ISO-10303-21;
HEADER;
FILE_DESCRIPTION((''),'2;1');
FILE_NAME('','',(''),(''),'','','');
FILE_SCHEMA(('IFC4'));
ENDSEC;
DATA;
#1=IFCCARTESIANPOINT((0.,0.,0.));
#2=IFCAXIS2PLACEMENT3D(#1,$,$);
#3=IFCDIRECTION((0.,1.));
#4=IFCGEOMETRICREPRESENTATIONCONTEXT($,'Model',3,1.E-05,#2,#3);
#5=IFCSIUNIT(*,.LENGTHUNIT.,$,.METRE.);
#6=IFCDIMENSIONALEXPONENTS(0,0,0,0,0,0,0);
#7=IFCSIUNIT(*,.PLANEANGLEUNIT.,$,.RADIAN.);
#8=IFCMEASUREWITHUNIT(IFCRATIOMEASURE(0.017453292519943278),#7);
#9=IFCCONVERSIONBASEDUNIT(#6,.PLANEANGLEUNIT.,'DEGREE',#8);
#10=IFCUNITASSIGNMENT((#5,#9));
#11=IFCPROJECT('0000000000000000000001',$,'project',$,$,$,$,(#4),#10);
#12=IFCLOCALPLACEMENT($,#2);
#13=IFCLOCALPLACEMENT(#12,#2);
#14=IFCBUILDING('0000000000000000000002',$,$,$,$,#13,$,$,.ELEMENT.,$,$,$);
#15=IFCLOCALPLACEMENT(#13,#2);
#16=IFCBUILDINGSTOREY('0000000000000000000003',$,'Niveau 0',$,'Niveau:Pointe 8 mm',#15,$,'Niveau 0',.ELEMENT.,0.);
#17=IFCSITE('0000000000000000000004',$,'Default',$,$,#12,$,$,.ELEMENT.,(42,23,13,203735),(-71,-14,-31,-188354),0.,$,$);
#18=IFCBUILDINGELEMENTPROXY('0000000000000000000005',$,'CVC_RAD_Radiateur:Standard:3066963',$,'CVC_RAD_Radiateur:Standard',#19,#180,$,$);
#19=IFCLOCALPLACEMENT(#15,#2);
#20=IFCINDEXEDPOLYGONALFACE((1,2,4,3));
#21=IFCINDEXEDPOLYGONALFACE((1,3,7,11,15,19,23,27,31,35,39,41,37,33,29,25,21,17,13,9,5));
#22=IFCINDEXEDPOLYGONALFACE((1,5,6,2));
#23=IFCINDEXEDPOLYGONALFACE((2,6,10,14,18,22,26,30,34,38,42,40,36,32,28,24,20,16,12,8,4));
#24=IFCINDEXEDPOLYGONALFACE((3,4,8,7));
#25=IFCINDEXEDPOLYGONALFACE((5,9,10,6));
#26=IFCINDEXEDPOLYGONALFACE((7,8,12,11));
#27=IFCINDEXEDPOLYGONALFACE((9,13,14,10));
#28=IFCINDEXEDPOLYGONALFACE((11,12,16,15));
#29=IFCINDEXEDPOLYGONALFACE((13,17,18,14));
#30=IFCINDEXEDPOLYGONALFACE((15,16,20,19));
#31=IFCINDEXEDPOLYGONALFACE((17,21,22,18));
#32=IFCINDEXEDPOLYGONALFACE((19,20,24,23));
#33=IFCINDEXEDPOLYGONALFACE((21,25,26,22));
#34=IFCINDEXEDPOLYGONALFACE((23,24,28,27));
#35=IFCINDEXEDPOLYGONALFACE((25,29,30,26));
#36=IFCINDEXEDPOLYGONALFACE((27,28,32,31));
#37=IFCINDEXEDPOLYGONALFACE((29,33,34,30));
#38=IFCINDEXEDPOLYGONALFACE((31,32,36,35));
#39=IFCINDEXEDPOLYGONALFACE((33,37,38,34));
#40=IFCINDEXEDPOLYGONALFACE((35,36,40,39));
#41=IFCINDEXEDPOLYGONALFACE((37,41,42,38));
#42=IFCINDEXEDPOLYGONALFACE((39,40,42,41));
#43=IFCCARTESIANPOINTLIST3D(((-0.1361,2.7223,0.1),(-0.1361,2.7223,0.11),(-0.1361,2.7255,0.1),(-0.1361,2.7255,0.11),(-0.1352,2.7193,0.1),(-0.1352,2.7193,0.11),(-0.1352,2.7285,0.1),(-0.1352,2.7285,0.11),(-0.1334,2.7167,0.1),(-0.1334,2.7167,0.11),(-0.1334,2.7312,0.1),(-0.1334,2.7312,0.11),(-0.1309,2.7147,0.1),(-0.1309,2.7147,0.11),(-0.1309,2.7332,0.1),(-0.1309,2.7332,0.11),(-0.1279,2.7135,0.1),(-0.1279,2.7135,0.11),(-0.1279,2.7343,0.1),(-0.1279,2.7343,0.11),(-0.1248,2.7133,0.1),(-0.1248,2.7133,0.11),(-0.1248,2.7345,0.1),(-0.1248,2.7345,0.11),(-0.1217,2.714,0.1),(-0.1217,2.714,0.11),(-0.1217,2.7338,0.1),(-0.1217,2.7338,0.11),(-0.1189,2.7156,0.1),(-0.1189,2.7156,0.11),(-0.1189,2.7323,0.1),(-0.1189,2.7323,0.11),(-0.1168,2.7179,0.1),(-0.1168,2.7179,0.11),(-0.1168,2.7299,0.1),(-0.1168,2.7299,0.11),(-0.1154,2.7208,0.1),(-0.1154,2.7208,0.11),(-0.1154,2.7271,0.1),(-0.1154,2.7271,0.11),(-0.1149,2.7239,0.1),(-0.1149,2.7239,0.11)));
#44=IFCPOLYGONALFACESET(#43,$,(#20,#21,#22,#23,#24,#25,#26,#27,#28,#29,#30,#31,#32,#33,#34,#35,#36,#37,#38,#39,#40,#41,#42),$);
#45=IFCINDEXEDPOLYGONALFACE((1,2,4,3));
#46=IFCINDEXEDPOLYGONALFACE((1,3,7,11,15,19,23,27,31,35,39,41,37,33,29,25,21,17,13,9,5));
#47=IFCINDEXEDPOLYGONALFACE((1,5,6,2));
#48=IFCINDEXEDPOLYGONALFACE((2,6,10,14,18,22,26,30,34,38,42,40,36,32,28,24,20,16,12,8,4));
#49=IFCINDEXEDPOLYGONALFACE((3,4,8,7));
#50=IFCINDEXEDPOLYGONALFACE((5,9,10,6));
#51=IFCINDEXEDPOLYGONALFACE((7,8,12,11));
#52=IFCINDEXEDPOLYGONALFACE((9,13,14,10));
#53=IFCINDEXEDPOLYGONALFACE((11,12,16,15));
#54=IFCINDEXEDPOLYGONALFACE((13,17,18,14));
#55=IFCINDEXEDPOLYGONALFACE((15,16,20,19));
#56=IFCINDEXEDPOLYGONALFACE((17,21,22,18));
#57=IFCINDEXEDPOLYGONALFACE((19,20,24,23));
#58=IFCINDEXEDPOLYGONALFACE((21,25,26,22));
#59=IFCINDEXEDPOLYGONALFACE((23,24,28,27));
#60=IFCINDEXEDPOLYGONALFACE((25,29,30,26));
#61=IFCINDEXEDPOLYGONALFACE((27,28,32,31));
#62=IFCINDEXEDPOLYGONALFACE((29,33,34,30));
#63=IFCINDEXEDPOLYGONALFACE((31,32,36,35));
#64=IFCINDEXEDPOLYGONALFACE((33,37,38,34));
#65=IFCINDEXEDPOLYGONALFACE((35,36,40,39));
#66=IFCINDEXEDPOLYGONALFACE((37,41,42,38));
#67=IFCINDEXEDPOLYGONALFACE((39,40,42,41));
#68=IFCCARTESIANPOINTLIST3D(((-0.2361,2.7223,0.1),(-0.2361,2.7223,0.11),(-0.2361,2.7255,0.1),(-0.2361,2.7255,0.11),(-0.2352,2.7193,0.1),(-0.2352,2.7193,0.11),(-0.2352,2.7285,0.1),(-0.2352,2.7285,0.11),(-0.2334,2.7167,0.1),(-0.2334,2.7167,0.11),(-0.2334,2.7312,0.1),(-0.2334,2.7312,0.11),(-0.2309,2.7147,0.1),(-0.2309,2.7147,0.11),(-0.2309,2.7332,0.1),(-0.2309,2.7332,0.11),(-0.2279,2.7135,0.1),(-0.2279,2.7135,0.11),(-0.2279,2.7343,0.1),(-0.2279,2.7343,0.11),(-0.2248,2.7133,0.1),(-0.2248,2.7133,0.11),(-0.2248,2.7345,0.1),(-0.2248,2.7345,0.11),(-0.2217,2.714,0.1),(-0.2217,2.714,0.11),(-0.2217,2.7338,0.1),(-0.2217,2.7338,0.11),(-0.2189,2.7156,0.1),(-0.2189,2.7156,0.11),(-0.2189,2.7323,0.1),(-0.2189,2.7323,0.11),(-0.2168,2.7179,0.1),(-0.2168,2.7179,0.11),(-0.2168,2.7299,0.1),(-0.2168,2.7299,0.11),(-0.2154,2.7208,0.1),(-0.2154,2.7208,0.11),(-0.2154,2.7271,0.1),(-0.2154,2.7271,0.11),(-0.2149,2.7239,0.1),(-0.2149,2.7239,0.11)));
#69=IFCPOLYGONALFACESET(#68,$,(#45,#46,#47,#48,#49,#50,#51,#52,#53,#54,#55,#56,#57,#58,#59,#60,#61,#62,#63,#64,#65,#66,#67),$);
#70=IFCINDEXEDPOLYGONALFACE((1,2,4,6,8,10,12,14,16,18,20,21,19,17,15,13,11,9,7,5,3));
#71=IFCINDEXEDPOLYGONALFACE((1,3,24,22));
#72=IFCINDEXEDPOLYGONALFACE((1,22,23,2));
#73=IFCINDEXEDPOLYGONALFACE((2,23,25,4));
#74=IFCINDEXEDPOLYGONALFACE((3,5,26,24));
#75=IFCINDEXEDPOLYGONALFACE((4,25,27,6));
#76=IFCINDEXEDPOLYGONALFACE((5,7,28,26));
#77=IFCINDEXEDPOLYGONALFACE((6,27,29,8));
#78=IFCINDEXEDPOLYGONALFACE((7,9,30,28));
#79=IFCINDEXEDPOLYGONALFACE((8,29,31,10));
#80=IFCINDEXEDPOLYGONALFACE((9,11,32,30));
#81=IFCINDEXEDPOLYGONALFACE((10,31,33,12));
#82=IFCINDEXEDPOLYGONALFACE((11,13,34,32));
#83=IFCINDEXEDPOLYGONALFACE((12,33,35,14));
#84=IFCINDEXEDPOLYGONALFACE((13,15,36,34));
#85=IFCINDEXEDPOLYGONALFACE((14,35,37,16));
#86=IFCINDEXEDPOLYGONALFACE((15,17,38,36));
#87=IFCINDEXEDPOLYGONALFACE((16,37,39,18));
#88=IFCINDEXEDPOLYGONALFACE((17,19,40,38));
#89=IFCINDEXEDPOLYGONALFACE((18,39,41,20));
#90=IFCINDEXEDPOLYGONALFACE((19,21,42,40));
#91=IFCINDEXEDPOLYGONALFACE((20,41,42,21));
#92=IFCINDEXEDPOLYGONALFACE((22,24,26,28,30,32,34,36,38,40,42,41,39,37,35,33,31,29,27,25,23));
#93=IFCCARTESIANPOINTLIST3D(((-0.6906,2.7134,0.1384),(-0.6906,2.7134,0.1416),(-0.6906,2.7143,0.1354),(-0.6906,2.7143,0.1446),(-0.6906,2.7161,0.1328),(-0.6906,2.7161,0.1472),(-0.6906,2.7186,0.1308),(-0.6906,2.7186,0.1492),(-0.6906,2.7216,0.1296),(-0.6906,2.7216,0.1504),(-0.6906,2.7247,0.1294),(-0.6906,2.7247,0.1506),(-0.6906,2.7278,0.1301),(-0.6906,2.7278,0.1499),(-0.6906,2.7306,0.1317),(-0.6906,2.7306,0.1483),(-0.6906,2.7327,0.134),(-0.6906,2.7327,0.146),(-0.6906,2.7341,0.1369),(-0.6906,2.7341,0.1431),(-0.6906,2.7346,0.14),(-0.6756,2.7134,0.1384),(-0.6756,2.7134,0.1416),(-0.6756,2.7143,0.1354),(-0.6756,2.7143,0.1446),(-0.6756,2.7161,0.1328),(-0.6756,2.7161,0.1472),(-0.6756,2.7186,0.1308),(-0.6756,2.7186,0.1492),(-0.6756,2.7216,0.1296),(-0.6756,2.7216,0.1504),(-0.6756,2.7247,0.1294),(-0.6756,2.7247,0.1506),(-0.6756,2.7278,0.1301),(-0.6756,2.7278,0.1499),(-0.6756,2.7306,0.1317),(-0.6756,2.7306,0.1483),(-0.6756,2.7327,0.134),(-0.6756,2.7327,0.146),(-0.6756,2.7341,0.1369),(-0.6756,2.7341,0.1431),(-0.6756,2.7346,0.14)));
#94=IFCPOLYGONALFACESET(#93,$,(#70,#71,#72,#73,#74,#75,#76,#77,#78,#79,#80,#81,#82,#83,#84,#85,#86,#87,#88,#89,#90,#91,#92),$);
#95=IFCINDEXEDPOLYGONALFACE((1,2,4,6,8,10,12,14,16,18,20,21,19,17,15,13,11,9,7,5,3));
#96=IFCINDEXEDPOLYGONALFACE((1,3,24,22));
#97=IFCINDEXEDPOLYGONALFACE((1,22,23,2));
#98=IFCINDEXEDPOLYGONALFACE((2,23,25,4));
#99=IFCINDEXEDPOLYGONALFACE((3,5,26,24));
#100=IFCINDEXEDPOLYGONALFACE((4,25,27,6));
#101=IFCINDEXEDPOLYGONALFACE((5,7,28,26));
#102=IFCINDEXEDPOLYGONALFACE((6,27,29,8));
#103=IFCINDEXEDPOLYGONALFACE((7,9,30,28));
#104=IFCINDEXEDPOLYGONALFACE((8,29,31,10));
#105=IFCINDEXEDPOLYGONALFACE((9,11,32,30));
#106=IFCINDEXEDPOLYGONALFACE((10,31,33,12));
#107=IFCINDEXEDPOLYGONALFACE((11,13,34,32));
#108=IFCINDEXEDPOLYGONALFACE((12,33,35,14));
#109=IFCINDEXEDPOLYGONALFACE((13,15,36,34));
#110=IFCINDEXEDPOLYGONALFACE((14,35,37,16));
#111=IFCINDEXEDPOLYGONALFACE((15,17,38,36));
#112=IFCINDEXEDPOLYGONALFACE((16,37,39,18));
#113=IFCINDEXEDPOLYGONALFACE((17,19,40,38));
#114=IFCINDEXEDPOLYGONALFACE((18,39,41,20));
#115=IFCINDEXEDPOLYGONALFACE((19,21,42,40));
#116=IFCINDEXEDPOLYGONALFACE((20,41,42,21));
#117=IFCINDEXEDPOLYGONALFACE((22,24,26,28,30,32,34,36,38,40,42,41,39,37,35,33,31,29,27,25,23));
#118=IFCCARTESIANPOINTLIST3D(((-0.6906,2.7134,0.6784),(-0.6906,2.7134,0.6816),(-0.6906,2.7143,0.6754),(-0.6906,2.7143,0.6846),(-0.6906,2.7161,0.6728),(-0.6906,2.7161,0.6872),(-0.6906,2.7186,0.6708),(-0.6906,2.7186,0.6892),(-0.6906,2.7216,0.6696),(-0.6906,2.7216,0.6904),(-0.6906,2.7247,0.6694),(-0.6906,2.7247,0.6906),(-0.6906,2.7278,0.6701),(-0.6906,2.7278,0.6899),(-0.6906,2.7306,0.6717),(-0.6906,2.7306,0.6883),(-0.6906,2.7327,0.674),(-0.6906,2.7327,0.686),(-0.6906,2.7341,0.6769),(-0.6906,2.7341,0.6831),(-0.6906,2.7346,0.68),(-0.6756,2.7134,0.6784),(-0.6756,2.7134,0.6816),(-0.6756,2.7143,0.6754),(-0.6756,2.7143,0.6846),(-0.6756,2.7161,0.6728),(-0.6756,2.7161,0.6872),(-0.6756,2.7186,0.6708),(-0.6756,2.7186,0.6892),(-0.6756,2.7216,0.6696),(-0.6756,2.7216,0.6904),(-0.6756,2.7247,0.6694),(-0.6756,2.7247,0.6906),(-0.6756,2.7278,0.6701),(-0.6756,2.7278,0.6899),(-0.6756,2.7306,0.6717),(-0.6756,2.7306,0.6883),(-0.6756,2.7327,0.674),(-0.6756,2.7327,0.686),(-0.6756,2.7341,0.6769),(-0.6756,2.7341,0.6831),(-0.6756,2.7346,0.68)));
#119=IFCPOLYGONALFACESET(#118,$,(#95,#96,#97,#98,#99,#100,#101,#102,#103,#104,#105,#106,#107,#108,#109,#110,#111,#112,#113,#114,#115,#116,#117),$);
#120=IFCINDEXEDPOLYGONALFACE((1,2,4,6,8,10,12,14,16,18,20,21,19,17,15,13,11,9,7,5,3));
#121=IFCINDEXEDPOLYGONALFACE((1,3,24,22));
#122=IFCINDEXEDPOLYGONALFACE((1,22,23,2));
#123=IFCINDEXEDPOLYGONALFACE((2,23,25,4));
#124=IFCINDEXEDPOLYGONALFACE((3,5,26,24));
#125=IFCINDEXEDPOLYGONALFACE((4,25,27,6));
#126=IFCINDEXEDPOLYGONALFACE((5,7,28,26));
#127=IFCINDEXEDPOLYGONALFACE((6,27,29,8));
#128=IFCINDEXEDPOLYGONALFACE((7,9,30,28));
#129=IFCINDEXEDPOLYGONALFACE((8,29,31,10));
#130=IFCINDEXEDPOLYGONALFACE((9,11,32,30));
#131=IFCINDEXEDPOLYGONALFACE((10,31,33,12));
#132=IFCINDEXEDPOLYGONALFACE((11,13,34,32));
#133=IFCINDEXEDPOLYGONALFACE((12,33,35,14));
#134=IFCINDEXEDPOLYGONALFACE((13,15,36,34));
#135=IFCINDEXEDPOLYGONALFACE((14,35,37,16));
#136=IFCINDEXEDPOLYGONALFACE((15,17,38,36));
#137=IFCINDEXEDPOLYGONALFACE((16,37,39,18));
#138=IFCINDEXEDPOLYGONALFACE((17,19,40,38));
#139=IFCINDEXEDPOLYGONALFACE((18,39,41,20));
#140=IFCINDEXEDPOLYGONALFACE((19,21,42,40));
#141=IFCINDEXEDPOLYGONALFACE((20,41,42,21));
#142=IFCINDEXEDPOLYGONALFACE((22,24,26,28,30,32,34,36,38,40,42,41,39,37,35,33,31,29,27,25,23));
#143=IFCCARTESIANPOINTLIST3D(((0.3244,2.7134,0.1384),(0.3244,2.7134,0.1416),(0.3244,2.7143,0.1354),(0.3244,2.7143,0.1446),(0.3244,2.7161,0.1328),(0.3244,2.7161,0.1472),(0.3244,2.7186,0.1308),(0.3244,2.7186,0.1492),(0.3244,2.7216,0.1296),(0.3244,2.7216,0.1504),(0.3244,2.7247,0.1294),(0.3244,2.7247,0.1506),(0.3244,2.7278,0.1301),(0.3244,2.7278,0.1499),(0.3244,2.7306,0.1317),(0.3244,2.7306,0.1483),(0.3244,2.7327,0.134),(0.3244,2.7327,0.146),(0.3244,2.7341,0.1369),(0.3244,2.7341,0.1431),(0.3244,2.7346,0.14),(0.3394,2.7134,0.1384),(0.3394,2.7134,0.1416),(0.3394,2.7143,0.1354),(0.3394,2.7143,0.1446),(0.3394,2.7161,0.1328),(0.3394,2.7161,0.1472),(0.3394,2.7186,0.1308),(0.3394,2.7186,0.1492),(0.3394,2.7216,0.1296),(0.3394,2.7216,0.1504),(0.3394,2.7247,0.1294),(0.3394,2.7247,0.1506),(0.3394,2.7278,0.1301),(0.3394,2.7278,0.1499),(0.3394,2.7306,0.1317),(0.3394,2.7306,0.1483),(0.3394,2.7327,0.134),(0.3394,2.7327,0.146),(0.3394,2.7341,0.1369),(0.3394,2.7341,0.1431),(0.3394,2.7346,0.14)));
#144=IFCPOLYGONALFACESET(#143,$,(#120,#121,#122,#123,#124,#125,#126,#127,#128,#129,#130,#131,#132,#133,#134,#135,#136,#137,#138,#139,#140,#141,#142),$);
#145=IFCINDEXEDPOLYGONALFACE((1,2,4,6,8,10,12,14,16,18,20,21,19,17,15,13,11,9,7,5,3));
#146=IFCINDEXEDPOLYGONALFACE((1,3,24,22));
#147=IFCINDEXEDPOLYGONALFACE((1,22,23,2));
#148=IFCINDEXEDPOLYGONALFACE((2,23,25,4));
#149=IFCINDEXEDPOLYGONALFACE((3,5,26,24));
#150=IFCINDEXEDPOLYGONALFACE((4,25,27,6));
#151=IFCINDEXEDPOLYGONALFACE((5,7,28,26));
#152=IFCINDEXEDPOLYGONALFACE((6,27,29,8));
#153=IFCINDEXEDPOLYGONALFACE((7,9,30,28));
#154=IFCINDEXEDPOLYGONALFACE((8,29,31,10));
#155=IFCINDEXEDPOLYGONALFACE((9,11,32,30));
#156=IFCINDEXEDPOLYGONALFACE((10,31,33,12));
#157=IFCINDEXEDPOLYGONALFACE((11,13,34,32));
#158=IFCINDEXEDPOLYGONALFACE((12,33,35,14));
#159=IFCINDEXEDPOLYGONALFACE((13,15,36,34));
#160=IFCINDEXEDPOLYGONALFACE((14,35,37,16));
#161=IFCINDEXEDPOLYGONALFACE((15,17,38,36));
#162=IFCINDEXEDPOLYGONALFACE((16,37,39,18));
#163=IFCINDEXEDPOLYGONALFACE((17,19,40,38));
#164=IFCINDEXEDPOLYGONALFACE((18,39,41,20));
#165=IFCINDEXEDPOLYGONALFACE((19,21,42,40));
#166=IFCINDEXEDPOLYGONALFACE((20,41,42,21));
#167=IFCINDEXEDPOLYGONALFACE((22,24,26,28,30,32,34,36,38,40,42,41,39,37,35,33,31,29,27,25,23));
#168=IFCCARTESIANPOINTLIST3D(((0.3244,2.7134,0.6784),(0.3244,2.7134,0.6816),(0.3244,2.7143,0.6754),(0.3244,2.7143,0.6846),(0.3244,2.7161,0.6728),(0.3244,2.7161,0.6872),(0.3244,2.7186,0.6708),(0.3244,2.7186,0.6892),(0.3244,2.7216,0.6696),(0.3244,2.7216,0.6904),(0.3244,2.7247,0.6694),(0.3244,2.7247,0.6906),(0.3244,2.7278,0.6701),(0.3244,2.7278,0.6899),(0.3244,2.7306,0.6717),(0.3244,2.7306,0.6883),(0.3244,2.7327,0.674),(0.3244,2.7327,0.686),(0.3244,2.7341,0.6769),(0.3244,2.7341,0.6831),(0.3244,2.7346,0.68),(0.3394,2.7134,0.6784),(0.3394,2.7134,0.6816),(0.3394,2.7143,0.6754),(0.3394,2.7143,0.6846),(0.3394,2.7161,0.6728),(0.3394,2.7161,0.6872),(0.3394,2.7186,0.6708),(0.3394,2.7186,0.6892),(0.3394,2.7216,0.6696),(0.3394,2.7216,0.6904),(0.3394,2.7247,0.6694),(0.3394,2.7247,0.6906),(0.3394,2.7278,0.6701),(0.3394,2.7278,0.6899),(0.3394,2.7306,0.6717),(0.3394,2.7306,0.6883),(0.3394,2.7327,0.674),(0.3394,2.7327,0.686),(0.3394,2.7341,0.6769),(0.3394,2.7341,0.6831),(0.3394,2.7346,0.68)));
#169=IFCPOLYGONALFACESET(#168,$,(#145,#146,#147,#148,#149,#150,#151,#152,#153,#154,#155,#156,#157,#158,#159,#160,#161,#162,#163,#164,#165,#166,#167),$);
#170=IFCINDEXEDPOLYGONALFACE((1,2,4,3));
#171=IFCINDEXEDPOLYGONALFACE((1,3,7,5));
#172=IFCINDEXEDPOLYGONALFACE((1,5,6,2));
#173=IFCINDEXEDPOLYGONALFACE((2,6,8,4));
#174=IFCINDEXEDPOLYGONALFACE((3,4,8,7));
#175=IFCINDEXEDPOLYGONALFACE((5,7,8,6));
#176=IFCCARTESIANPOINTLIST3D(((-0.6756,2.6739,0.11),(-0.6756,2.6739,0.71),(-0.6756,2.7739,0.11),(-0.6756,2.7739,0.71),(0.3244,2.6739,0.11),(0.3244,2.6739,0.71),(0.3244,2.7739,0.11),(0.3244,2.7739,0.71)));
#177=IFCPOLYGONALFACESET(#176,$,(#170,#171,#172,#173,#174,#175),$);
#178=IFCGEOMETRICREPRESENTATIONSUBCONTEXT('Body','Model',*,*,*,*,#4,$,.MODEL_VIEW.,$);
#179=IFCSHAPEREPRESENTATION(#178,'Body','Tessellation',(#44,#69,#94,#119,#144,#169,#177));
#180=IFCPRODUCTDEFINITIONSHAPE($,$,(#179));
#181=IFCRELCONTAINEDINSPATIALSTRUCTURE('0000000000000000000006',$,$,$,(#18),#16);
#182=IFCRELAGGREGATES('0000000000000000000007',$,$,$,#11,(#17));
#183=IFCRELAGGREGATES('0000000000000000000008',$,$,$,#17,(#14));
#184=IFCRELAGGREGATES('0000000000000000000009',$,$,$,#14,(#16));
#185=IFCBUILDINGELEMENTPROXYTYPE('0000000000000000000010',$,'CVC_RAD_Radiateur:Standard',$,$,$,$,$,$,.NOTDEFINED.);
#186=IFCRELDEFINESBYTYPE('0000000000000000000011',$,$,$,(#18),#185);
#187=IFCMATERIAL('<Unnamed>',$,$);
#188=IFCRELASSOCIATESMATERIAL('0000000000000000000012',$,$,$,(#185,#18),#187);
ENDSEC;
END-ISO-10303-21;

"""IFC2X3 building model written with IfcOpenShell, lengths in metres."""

from ifc_helpers import new_model, entity, si_unit, converted_unit, direction, frame, frame_2d, origin, origin_2d_with_axis, place, context, subcontext, project, spatial, rectangle, circle, extrude, source, transform, mapped, material, type_object, type_shapes, element, save


model = new_model("IFC2X3")

# Units and contexts
model_context = context("Model", 3, precision=1e-05, world=origin(), true_north=direction((0.0, 1.0)))
body_context = subcontext(model_context, "Body", "Model", "MODEL_VIEW")
ifc_project = project(units=[si_unit("LENGTHUNIT", "METRE"), converted_unit("PLANEANGLEUNIT", "DEGREE", entity("IfcRatioMeasure", 0.017453292519943278), si_unit("PLANEANGLEUNIT", "RADIAN"), dimensions=[0, 0, 0, 0, 0, 0, 0])], contexts=[model_context])

# Site, building, storey
site_placement = place(None, origin())
site = spatial("IfcSite", under=ifc_project, at=site_placement, Name="Default", CompositionType="ELEMENT", RefLatitude=(42, 23, 13, 203735), RefLongitude=(-71, -14, -31, -188354), RefElevation=0.0)
building_placement = place(site_placement, origin())
building = spatial("IfcBuilding", under=site, at=building_placement, CompositionType="ELEMENT")
storey_placement = place(building_placement, origin())
storey = spatial("IfcBuildingStorey", under=building, at=storey_placement, Name="Niveau 0", ObjectType="Niveau:Pointe 8 mm", LongName="Niveau 0", CompositionType="ELEMENT", Elevation=0.0)

# Building element proxy
ifc_material = material(Name="<Unnamed>")
building_element_proxy_type = type_object("IfcBuildingElementProxyType", Name="CVC_RAD_Radiateur:Standard", PredefinedType="NOTDEFINED", material=ifc_material)
shared_shape = source(origin(), body_context, "Body", "SweptSolid", [
    extrude(circle(Radius=0.0107, at=frame_2d((0.0, 0.0), x_axis=(1.0, 0.0))), frame((0.05, 0.055, 0.0)), (0.0, 0.0, 1.0), 0.01),
    extrude(circle(Radius=0.0107, at=frame_2d((0.0, 0.0), x_axis=(1.0, 0.0))), frame((-0.05, 0.055, 0.0)), (0.0, 0.0, 1.0), 0.01),
    extrude(circle(Radius=0.0107, at=frame_2d((0.0, 0.0), x_axis=(1.0, 0.0))), frame((-0.515, 0.055, 0.04), z_axis=(1.0, 0.0, 0.0), x_axis=(0.0, 1.0, 0.0)), (0.0, 0.0, 1.0), 0.015),
    extrude(circle(Radius=0.0107, at=frame_2d((0.0, 0.0), x_axis=(1.0, 0.0))), frame((-0.515, 0.055, 0.58), z_axis=(1.0, 0.0, 0.0), x_axis=(0.0, 1.0, 0.0)), (0.0, 0.0, 1.0), 0.015),
    extrude(circle(Radius=0.0107, at=frame_2d((0.0, 0.0), x_axis=(1.0, 0.0))), frame((0.5, 0.055, 0.04), z_axis=(1.0, 0.0, 0.0), x_axis=(0.0, 1.0, 0.0)), (0.0, 0.0, 1.0), 0.015),
    extrude(circle(Radius=0.0107, at=origin_2d_with_axis()), frame((0.5, 0.055, 0.58), z_axis=(1.0, 0.0, 0.0), x_axis=(0.0, 1.0, 0.0)), (0.0, 0.0, 1.0), 0.015),
    extrude(rectangle(XDim=1.0, YDim=0.1, at=origin_2d_with_axis()), frame((0.0, 0.055, 0.01), z_axis=(0.0, 0.0, 1.0), x_axis=(-1.0, 0.0, 0.0)), (0.0, 0.0, 1.0), 0.6),
])
type_shapes(building_element_proxy_type, [shared_shape])
for number, where, name in (
    (1, (-0.1756, 2.6689, 0.1), "CVC_RAD_Radiateur:Standard:3066963"),
):
    element("IfcBuildingElementProxy", number, at=place(storey_placement, frame(where)), inside=storey, type_object=building_element_proxy_type, material=ifc_material, Name=name, ObjectType="CVC_RAD_Radiateur:Standard", context=body_context, shape_type="MappedRepresentation", body=[
        mapped(shared_shape, transform((0.0, 0.0, 0.0), scale=1.0)),
    ])

save(model, "model.ifc")
